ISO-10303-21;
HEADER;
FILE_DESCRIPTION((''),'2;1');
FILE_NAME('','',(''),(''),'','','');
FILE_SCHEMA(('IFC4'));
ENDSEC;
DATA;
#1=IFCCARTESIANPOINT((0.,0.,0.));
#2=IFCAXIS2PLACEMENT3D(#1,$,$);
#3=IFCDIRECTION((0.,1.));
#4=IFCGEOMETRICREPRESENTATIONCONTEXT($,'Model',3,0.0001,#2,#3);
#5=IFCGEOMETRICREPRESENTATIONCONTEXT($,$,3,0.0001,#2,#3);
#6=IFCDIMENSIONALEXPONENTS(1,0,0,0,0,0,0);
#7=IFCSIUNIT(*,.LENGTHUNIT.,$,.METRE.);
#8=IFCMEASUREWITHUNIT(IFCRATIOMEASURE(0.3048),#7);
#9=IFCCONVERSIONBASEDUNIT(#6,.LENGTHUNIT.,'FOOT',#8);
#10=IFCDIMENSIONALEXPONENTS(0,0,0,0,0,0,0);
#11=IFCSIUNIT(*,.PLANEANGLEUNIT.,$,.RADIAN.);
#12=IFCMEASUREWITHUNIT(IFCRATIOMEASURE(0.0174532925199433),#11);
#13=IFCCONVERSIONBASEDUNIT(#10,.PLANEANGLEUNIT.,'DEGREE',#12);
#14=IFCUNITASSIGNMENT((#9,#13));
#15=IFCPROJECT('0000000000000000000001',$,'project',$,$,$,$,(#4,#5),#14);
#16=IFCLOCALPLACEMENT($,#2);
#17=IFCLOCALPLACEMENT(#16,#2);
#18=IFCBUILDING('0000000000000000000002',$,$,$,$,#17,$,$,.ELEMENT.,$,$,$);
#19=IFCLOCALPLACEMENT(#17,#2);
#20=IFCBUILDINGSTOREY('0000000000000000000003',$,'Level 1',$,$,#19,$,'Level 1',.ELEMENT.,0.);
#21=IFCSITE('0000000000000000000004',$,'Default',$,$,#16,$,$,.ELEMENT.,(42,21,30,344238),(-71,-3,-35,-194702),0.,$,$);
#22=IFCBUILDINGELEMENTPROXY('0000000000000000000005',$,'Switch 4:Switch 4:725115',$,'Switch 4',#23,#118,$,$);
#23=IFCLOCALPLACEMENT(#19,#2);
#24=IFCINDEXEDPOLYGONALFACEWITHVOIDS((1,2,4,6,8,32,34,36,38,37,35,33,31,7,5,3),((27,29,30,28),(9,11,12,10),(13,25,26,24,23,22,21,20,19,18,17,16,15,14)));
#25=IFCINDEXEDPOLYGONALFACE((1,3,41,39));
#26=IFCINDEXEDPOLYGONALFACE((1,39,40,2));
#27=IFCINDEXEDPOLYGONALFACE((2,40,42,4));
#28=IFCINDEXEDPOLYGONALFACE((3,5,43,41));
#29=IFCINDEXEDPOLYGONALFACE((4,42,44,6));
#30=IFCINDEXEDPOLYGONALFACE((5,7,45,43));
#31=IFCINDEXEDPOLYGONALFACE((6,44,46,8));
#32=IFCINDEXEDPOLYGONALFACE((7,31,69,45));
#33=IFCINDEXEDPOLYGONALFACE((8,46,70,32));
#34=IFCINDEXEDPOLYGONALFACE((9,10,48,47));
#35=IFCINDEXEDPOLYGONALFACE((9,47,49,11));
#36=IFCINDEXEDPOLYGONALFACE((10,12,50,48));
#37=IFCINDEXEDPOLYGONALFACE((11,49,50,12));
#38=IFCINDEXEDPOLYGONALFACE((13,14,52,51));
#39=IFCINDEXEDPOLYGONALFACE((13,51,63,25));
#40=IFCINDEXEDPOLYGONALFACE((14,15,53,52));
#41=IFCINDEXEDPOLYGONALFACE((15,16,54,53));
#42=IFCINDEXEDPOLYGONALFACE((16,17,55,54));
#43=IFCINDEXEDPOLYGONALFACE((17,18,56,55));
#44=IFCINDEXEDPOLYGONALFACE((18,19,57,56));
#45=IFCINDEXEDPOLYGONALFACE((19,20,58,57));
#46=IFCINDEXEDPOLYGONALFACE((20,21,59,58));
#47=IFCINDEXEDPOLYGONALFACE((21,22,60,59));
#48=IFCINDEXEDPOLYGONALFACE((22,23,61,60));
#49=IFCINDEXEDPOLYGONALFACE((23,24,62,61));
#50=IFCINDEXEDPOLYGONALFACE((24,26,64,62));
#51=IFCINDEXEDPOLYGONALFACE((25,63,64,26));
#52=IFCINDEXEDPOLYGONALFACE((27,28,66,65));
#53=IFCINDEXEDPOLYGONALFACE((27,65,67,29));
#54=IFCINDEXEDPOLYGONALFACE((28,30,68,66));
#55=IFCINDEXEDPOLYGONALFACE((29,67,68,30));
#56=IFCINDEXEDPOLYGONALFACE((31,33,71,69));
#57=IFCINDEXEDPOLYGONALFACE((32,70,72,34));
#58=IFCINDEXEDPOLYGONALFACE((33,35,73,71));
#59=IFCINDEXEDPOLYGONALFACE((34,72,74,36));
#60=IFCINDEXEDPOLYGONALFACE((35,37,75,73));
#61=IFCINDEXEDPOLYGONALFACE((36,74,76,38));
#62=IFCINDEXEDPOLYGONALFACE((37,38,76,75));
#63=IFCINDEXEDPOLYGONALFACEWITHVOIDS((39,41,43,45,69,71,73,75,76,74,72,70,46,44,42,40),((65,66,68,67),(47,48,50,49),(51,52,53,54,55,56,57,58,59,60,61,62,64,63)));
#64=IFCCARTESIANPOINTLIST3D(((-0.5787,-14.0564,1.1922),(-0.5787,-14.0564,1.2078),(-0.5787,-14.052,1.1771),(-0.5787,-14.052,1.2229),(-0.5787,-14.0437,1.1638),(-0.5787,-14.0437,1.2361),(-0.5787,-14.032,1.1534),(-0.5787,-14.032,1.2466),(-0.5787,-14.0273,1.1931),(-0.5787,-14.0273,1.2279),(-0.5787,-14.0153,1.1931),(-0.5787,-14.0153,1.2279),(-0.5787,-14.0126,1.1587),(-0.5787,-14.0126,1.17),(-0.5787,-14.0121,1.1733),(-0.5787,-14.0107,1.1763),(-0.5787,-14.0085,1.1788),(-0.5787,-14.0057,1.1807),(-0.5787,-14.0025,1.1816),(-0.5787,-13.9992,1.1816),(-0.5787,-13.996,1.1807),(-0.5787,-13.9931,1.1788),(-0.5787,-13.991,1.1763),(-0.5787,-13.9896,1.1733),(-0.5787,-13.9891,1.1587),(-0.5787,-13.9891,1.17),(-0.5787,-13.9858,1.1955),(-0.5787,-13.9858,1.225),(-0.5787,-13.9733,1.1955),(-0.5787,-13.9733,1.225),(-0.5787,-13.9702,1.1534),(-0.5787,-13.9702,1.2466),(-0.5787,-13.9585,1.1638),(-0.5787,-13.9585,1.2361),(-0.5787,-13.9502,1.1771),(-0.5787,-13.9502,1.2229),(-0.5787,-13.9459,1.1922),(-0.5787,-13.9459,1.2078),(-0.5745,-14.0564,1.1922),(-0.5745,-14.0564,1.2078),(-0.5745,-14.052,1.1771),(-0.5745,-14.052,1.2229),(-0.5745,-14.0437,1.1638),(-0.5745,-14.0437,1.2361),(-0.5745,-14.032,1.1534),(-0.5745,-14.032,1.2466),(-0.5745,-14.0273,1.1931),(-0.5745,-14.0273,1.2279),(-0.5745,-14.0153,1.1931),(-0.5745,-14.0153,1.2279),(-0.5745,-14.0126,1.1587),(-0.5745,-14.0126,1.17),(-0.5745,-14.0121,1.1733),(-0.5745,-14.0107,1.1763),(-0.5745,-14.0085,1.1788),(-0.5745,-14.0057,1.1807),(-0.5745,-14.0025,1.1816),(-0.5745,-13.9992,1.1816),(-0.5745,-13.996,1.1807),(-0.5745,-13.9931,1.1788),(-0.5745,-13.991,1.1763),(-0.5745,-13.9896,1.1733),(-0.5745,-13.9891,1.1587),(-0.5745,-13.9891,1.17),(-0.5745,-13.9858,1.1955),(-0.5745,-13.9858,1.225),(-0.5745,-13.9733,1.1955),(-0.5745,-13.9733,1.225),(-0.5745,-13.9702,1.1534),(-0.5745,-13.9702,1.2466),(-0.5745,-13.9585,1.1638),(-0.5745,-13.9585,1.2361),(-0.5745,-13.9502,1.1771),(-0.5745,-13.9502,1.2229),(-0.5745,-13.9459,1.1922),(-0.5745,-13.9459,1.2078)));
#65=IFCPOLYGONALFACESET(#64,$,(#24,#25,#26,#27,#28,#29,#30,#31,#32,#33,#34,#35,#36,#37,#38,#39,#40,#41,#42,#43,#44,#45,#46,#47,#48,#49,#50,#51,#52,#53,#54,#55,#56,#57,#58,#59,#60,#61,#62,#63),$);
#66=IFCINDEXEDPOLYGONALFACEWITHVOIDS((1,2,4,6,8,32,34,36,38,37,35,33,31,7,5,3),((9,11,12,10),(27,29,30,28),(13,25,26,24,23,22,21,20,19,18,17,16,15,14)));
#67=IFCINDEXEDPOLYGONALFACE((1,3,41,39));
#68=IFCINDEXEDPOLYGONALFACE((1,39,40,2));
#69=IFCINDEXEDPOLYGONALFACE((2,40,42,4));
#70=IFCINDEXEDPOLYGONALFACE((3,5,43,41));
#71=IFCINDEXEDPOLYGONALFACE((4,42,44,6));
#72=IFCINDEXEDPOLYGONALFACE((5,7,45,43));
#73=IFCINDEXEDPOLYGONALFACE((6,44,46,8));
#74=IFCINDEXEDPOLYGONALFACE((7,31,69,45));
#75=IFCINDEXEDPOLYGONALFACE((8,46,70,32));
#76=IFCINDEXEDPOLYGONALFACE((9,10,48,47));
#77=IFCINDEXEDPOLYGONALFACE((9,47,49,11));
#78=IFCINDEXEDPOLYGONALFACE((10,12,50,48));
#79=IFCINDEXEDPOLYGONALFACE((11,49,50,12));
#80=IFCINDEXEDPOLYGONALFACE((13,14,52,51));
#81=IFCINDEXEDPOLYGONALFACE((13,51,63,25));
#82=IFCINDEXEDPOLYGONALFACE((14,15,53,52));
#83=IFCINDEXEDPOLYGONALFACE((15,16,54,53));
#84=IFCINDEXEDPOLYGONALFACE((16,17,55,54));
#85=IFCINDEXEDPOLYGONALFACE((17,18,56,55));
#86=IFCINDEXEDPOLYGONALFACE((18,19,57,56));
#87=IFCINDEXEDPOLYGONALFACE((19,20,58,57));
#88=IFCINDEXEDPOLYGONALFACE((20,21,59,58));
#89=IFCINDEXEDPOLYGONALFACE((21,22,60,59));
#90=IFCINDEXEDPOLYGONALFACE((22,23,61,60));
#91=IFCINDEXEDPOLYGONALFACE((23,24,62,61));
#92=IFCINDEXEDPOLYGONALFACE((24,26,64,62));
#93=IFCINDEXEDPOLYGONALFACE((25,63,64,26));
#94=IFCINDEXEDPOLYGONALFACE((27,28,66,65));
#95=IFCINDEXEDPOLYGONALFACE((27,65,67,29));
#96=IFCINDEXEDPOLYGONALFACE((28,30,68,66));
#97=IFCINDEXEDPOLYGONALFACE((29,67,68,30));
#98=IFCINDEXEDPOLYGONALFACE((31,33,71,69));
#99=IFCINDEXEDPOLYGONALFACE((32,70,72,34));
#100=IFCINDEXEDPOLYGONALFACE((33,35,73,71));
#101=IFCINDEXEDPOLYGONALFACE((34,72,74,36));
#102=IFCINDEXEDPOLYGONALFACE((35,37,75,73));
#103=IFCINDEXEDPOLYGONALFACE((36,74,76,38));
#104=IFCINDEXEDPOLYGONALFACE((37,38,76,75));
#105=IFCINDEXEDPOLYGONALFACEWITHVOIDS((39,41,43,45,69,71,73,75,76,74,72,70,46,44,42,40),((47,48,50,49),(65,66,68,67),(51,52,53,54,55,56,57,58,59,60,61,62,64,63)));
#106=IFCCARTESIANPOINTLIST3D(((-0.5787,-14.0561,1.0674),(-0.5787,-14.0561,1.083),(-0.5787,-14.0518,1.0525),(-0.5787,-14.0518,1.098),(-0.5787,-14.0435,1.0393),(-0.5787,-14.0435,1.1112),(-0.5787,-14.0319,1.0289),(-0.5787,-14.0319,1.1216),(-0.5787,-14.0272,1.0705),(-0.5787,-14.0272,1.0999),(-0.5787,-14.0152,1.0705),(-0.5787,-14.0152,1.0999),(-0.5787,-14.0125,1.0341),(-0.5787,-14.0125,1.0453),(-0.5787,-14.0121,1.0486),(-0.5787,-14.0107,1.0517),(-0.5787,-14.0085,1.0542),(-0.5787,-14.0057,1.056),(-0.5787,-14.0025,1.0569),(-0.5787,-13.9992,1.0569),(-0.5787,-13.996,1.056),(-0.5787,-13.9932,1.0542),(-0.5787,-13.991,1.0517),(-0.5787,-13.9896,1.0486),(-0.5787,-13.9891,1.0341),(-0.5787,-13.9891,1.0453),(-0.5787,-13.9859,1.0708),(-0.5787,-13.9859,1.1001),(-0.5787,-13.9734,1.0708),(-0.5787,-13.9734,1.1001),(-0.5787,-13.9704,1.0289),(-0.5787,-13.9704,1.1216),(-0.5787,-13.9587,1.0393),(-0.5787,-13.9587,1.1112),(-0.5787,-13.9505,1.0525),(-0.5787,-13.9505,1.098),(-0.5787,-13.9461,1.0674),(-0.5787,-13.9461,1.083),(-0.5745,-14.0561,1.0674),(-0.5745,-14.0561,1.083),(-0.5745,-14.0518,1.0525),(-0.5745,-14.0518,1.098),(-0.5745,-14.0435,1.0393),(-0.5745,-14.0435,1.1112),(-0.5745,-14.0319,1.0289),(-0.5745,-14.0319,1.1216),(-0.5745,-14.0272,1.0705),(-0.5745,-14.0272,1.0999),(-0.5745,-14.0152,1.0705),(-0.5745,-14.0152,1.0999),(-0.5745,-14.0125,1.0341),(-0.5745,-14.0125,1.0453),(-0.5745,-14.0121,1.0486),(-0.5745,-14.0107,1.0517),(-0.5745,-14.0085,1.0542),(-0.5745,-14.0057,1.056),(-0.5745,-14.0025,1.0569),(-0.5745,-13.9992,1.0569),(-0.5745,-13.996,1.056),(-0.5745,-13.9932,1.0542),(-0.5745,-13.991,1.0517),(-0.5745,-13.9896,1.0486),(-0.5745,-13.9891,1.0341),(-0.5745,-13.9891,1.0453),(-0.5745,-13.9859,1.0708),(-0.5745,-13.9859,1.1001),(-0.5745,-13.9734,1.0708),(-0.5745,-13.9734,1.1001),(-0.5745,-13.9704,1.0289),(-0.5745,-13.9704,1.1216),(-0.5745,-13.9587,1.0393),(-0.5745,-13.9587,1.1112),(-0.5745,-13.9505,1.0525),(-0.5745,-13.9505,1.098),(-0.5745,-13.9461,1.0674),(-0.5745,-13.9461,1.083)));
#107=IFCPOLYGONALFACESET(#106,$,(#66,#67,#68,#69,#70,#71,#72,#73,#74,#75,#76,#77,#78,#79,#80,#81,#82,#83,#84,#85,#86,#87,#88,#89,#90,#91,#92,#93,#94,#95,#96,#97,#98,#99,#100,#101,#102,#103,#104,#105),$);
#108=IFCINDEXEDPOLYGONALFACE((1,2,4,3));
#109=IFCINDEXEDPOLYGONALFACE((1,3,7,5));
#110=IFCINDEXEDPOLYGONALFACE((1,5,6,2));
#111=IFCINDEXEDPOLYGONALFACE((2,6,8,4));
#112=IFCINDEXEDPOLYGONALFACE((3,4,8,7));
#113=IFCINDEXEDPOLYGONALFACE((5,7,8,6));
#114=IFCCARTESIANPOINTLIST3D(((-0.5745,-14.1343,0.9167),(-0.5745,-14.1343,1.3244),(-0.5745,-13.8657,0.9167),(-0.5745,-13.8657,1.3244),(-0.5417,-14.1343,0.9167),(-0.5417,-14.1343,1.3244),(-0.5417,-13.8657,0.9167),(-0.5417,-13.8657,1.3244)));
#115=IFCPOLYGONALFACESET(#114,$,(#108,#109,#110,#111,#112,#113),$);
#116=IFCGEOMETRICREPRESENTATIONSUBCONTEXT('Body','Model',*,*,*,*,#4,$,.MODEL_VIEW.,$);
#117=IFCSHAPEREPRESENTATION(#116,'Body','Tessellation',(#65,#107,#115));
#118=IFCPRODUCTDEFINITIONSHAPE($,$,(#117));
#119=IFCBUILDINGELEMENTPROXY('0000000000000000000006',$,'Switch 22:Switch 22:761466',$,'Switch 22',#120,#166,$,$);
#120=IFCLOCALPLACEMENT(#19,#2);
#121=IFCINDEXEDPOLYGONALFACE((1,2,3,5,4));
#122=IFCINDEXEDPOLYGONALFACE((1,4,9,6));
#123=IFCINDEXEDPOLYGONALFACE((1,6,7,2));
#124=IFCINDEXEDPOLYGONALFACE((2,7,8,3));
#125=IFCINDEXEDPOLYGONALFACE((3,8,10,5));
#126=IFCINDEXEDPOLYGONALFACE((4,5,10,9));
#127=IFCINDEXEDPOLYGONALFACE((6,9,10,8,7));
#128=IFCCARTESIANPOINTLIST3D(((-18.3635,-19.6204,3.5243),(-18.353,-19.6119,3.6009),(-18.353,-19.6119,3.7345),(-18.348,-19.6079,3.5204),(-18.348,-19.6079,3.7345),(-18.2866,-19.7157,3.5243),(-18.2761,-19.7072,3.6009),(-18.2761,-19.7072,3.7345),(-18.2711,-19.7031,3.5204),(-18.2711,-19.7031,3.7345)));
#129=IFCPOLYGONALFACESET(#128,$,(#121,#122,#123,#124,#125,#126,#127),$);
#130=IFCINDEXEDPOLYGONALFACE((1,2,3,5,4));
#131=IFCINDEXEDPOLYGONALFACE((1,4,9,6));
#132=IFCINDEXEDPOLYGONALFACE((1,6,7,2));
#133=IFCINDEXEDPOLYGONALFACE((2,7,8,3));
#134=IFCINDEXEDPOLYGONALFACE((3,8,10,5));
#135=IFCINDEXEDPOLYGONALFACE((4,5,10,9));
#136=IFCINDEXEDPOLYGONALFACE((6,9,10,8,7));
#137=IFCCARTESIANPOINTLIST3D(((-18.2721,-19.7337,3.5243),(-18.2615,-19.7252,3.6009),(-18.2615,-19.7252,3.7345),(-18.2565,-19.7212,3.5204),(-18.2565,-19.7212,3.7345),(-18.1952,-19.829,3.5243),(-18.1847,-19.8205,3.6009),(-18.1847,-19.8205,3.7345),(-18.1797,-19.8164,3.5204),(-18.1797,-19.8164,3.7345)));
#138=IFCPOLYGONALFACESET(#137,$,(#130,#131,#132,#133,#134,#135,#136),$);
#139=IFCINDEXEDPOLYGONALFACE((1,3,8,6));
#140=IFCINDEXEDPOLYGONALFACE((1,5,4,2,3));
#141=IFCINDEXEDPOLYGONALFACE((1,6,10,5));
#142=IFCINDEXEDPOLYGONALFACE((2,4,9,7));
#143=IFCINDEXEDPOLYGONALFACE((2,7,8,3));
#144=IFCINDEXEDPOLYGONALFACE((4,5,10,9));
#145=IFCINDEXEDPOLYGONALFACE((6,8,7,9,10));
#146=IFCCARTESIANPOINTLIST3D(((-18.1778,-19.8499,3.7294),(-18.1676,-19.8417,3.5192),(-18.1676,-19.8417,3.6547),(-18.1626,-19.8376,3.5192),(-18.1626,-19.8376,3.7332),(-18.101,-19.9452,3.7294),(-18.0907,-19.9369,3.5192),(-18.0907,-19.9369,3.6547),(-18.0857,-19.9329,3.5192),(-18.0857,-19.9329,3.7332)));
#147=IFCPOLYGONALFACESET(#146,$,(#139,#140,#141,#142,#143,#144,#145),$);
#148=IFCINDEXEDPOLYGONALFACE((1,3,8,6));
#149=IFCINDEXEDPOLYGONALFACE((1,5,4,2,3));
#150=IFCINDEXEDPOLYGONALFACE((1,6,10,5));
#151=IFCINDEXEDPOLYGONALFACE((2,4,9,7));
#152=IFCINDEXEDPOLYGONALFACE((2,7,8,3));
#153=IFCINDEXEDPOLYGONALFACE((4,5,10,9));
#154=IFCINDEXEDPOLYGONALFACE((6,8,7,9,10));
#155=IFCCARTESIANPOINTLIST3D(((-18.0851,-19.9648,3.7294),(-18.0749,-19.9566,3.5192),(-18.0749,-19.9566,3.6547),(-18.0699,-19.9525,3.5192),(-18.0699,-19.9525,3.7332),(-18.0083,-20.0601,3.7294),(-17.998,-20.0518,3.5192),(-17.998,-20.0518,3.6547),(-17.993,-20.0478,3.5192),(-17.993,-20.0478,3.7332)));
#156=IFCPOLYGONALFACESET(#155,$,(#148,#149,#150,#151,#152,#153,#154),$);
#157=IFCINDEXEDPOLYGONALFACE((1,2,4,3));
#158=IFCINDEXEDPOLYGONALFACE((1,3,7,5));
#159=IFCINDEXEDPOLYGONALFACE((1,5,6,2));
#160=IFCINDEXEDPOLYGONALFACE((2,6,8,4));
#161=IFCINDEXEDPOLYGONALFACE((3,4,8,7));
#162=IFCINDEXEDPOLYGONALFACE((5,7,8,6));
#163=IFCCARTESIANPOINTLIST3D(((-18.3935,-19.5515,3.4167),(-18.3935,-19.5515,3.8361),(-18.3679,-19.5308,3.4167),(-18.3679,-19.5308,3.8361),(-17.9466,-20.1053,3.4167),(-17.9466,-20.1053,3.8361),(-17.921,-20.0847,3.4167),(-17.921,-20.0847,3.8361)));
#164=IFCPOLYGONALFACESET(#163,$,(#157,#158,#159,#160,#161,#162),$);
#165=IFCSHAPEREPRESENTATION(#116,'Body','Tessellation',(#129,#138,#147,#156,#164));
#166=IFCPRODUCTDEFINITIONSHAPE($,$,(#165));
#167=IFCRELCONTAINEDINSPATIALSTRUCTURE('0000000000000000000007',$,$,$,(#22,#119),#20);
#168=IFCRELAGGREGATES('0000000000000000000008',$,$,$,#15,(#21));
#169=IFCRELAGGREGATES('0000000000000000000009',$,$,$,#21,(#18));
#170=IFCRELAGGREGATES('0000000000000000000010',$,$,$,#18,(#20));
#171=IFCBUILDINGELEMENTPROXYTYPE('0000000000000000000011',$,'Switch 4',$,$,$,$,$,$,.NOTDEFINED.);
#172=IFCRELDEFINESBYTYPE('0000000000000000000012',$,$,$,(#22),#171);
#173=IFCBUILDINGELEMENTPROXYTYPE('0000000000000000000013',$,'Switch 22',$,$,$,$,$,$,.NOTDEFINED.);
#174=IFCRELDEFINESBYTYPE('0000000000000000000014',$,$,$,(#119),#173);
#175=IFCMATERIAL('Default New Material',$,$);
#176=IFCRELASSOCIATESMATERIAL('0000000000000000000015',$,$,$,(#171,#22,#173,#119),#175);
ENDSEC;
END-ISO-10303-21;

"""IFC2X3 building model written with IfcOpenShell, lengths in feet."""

from ifc_helpers import new_model, entity, si_unit, converted_unit, direction, frame, frame_2d, origin, origin_2d_with_axis, place, context, subcontext, project, spatial, polyline, circle_curve, parameter, trimmed, segment, composite_curve, rectangle, outline, extrude, source, transform, mapped, material, type_object, type_shapes, element, save


model = new_model("IFC2X3")

# Units and contexts
model_context = context("Model", 3, precision=0.0001, world=origin(), true_north=direction((0.0, 1.0)))
context_of_model = context(None, 3, precision=0.0001, world=origin(), true_north=direction((0.0, 1.0)))
body_context = subcontext(model_context, "Body", "Model", "MODEL_VIEW")
ifc_project = project(units=[converted_unit("LENGTHUNIT", "FOOT", entity("IfcRatioMeasure", 0.3048), si_unit("LENGTHUNIT", "METRE"), dimensions=[1, 0, 0, 0, 0, 0, 0]), converted_unit("PLANEANGLEUNIT", "DEGREE", entity("IfcRatioMeasure", 0.0174532925199433), si_unit("PLANEANGLEUNIT", "RADIAN"), dimensions=[0, 0, 0, 0, 0, 0, 0])], contexts=[model_context, context_of_model])

# Site, building, storey
site_placement = place(None, origin())
site = spatial("IfcSite", under=ifc_project, at=site_placement, Name="Default", CompositionType="ELEMENT", RefLatitude=(42, 21, 30, 344238), RefLongitude=(-71, -3, -35, -194702), RefElevation=0.0)
building_placement = place(site_placement, origin())
building = spatial("IfcBuilding", under=site, at=building_placement, CompositionType="ELEMENT")
storey_placement = place(building_placement, origin())
storey = spatial("IfcBuildingStorey", under=building, at=storey_placement, Name="Level 1", LongName="Level 1", CompositionType="ELEMENT", Elevation=0.0)

# Shared definitions
ifc_material = material(Name="Default New Material")

# Building element proxies
building_element_proxy_type_1 = type_object("IfcBuildingElementProxyType", Name="Switch 4", PredefinedType="NOTDEFINED", material=ifc_material)
shared_shape_1 = source(origin(), body_context, "Body", "SweptSolid", [
    extrude(outline(composite_curve([segment(polyline([(-0.0309, -0.0466), (0.0309, -0.0466)]), True, "CONTINUOUS"), segment(trimmed(circle_curve(frame_2d((-0.0003, 0.0), x_axis=(-1.0, 0.0)), 0.0561), [parameter(123.794741)], [parameter(236.205259)], True, "PARAMETER"), True, "CONTINUOUS"), segment(polyline([(0.0309, 0.0466), (-0.0309, 0.0466)]), True, "CONTINUOUS"), segment(trimmed(circle_curve(frame_2d((0.0003, 0.0), x_axis=(1.0, 0.0)), 0.0561), [parameter(123.794741)], [parameter(236.205259)], True, "PARAMETER"), True, "CONTINUOUS")], self_intersect=False), holes=[polyline([(0.0142, 0.0279), (0.0262, 0.0279), (0.0262, -0.0069), (0.0142, -0.0069), (0.0142, 0.0279)]), polyline([(-0.0153, 0.025), (-0.0153, -0.0045), (-0.0278, -0.0045), (-0.0278, 0.025), (-0.0153, 0.025)]), composite_curve([segment(polyline([(-0.012, -0.0413), (-0.012, -0.03)]), True, "CONTINUOUS"), segment(trimmed(circle_curve(frame_2d((-0.0003, -0.03), x_axis=(-1.0, 0.0)), 0.0117), [parameter(180.0)], [parameter(0.0)], True, "PARAMETER"), False, "CONTINUOUS"), segment(polyline([(0.0115, -0.03), (0.0115, -0.0413)]), True, "CONTINUOUS"), segment(polyline([(0.0115, -0.0413), (-0.012, -0.0413)]), True, "CONTINUOUS")], self_intersect=False)]), frame((-0.0011, 0.0328, 0.2833), z_axis=(0.0, 1.0, 0.0), x_axis=(-1.0, 0.0, 0.0)), (0.0, 0.0, 1.0), 0.0042),
    extrude(outline(composite_curve([segment(polyline([(-0.0308, -0.0464), (0.0308, -0.0464)]), True, "CONTINUOUS"), segment(trimmed(circle_curve(frame_2d((-0.0003, 0.0), x_axis=(-1.0, 0.0)), 0.0558), [parameter(123.794741)], [parameter(236.205259)], True, "PARAMETER"), True, "CONTINUOUS"), segment(polyline([(0.0308, 0.0464), (-0.0308, 0.0464)]), True, "CONTINUOUS"), segment(trimmed(circle_curve(frame_2d((0.0003, 0.0), x_axis=(1.0, 0.0)), 0.0558), [parameter(123.794741)], [parameter(236.205259)], True, "PARAMETER"), True, "CONTINUOUS")], self_intersect=False), holes=[polyline([(0.0141, 0.0247), (0.026, 0.0247), (0.026, -0.0047), (0.0141, -0.0047), (0.0141, 0.0247)]), polyline([(-0.0152, 0.0249), (-0.0152, -0.0045), (-0.0277, -0.0045), (-0.0277, 0.0249), (-0.0152, 0.0249)]), composite_curve([segment(polyline([(-0.012, -0.0411), (-0.012, -0.0299)]), True, "CONTINUOUS"), segment(trimmed(circle_curve(frame_2d((-0.0003, -0.0299), x_axis=(-1.0, 0.0)), 0.0117), [parameter(180.0)], [parameter(0.0)], True, "PARAMETER"), False, "CONTINUOUS"), segment(polyline([(0.0114, -0.0299), (0.0114, -0.0411)]), True, "CONTINUOUS"), segment(polyline([(0.0114, -0.0411), (-0.012, -0.0411)]), True, "CONTINUOUS")], self_intersect=False)]), frame((-0.0011, 0.0328, 0.1586), z_axis=(0.0, 1.0, 0.0), x_axis=(-1.0, 0.0, 0.0)), (0.0, 0.0, 1.0), 0.0042),
    extrude(rectangle(XDim=0.0328, YDim=0.2687, at=origin_2d_with_axis()), frame((0.0, 0.0164, 0.0), z_axis=(0.0, 0.0, 1.0), x_axis=(0.0, -1.0, 0.0)), (0.0, 0.0, 1.0), 0.4078),
])
type_shapes(building_element_proxy_type_1, [shared_shape_1])
proxy_1_placement = place(storey_placement, frame((-0.5417, -14.0, 0.9167), z_axis=(0.0, 0.0, 1.0), x_axis=(0.0, 1.0, 0.0)))
element("IfcBuildingElementProxy", 1, at=proxy_1_placement, inside=storey, type_object=building_element_proxy_type_1, material=ifc_material, Name="Switch 4:Switch 4:725115", ObjectType="Switch 4", context=body_context, shape_type="MappedRepresentation", body=[
    mapped(shared_shape_1, transform((0.0, 0.0, 0.0), scale=1.0)),
])
building_element_proxy_type_2 = type_object("IfcBuildingElementProxyType", Name="Switch 22", PredefinedType="NOTDEFINED", material=ifc_material)
shared_shape_2 = source(origin(), body_context, "Body", "SweptSolid", [
    extrude(outline(polyline([(-0.026, -0.0993), (-0.0057, -0.0993), (-0.0043, -0.0216), (0.0212, 0.1095), (0.0148, 0.1107), (-0.026, -0.0993)])), frame((0.2158, 0.0394, 0.2062), z_axis=(1.0, 0.0, 0.0), x_axis=(0.0, 0.981627, 0.190809)), (0.0, 0.0, 1.0), 0.1224),
    extrude(outline(polyline([(-0.026, -0.0993), (-0.0057, -0.0993), (-0.0043, -0.0216), (0.0212, 0.1095), (0.0148, 0.1107), (-0.026, -0.0993)])), frame((0.0702, 0.0394, 0.2062), z_axis=(1.0, 0.0, 0.0), x_axis=(0.0, 0.981627, 0.190809)), (0.0, 0.0, 1.0), 0.1224),
    extrude(outline(polyline([(-0.1021, -0.0065), (0.1119, -0.0065), (0.1119, -0.0001), (-0.0236, -0.0001), (-0.0983, 0.0131), (-0.1021, -0.0065)])), frame((-0.0794, 0.0394, 0.2145), z_axis=(1.0, 0.0, 0.0), x_axis=(0.0, 0.0, -1.0)), (0.0, 0.0, 1.0), 0.1224),
    extrude(outline(polyline([(-0.1021, -0.0065), (0.1119, -0.0065), (0.1119, -0.0001), (-0.0236, -0.0001), (-0.0983, 0.0131), (-0.1021, -0.0065)])), frame((-0.2271, 0.0394, 0.2145), z_axis=(1.0, 0.0, 0.0), x_axis=(0.0, 0.0, -1.0)), (0.0, 0.0, 1.0), 0.1224),
    extrude(rectangle(XDim=0.0329, YDim=0.7116, at=origin_2d_with_axis()), frame((0.0548, 0.0164, 0.0), z_axis=(0.0, 0.0, 1.0), x_axis=(0.0, -1.0, 0.0)), (0.0, 0.0, 1.0), 0.4194),
])
type_shapes(building_element_proxy_type_2, [shared_shape_2])
proxy_2_placement = place(storey_placement, frame((-18.11, -19.8504, 3.4167), z_axis=(0.0, 0.0, 1.0), x_axis=(-0.627919, 0.778278, 0.0)))
element("IfcBuildingElementProxy", 2, at=proxy_2_placement, inside=storey, type_object=building_element_proxy_type_2, material=ifc_material, Name="Switch 22:Switch 22:761466", ObjectType="Switch 22", context=body_context, shape_type="MappedRepresentation", body=[
    mapped(shared_shape_2, transform((0.0, 0.0, 0.0), scale=1.0)),
])

save(model, "model.ifc")
